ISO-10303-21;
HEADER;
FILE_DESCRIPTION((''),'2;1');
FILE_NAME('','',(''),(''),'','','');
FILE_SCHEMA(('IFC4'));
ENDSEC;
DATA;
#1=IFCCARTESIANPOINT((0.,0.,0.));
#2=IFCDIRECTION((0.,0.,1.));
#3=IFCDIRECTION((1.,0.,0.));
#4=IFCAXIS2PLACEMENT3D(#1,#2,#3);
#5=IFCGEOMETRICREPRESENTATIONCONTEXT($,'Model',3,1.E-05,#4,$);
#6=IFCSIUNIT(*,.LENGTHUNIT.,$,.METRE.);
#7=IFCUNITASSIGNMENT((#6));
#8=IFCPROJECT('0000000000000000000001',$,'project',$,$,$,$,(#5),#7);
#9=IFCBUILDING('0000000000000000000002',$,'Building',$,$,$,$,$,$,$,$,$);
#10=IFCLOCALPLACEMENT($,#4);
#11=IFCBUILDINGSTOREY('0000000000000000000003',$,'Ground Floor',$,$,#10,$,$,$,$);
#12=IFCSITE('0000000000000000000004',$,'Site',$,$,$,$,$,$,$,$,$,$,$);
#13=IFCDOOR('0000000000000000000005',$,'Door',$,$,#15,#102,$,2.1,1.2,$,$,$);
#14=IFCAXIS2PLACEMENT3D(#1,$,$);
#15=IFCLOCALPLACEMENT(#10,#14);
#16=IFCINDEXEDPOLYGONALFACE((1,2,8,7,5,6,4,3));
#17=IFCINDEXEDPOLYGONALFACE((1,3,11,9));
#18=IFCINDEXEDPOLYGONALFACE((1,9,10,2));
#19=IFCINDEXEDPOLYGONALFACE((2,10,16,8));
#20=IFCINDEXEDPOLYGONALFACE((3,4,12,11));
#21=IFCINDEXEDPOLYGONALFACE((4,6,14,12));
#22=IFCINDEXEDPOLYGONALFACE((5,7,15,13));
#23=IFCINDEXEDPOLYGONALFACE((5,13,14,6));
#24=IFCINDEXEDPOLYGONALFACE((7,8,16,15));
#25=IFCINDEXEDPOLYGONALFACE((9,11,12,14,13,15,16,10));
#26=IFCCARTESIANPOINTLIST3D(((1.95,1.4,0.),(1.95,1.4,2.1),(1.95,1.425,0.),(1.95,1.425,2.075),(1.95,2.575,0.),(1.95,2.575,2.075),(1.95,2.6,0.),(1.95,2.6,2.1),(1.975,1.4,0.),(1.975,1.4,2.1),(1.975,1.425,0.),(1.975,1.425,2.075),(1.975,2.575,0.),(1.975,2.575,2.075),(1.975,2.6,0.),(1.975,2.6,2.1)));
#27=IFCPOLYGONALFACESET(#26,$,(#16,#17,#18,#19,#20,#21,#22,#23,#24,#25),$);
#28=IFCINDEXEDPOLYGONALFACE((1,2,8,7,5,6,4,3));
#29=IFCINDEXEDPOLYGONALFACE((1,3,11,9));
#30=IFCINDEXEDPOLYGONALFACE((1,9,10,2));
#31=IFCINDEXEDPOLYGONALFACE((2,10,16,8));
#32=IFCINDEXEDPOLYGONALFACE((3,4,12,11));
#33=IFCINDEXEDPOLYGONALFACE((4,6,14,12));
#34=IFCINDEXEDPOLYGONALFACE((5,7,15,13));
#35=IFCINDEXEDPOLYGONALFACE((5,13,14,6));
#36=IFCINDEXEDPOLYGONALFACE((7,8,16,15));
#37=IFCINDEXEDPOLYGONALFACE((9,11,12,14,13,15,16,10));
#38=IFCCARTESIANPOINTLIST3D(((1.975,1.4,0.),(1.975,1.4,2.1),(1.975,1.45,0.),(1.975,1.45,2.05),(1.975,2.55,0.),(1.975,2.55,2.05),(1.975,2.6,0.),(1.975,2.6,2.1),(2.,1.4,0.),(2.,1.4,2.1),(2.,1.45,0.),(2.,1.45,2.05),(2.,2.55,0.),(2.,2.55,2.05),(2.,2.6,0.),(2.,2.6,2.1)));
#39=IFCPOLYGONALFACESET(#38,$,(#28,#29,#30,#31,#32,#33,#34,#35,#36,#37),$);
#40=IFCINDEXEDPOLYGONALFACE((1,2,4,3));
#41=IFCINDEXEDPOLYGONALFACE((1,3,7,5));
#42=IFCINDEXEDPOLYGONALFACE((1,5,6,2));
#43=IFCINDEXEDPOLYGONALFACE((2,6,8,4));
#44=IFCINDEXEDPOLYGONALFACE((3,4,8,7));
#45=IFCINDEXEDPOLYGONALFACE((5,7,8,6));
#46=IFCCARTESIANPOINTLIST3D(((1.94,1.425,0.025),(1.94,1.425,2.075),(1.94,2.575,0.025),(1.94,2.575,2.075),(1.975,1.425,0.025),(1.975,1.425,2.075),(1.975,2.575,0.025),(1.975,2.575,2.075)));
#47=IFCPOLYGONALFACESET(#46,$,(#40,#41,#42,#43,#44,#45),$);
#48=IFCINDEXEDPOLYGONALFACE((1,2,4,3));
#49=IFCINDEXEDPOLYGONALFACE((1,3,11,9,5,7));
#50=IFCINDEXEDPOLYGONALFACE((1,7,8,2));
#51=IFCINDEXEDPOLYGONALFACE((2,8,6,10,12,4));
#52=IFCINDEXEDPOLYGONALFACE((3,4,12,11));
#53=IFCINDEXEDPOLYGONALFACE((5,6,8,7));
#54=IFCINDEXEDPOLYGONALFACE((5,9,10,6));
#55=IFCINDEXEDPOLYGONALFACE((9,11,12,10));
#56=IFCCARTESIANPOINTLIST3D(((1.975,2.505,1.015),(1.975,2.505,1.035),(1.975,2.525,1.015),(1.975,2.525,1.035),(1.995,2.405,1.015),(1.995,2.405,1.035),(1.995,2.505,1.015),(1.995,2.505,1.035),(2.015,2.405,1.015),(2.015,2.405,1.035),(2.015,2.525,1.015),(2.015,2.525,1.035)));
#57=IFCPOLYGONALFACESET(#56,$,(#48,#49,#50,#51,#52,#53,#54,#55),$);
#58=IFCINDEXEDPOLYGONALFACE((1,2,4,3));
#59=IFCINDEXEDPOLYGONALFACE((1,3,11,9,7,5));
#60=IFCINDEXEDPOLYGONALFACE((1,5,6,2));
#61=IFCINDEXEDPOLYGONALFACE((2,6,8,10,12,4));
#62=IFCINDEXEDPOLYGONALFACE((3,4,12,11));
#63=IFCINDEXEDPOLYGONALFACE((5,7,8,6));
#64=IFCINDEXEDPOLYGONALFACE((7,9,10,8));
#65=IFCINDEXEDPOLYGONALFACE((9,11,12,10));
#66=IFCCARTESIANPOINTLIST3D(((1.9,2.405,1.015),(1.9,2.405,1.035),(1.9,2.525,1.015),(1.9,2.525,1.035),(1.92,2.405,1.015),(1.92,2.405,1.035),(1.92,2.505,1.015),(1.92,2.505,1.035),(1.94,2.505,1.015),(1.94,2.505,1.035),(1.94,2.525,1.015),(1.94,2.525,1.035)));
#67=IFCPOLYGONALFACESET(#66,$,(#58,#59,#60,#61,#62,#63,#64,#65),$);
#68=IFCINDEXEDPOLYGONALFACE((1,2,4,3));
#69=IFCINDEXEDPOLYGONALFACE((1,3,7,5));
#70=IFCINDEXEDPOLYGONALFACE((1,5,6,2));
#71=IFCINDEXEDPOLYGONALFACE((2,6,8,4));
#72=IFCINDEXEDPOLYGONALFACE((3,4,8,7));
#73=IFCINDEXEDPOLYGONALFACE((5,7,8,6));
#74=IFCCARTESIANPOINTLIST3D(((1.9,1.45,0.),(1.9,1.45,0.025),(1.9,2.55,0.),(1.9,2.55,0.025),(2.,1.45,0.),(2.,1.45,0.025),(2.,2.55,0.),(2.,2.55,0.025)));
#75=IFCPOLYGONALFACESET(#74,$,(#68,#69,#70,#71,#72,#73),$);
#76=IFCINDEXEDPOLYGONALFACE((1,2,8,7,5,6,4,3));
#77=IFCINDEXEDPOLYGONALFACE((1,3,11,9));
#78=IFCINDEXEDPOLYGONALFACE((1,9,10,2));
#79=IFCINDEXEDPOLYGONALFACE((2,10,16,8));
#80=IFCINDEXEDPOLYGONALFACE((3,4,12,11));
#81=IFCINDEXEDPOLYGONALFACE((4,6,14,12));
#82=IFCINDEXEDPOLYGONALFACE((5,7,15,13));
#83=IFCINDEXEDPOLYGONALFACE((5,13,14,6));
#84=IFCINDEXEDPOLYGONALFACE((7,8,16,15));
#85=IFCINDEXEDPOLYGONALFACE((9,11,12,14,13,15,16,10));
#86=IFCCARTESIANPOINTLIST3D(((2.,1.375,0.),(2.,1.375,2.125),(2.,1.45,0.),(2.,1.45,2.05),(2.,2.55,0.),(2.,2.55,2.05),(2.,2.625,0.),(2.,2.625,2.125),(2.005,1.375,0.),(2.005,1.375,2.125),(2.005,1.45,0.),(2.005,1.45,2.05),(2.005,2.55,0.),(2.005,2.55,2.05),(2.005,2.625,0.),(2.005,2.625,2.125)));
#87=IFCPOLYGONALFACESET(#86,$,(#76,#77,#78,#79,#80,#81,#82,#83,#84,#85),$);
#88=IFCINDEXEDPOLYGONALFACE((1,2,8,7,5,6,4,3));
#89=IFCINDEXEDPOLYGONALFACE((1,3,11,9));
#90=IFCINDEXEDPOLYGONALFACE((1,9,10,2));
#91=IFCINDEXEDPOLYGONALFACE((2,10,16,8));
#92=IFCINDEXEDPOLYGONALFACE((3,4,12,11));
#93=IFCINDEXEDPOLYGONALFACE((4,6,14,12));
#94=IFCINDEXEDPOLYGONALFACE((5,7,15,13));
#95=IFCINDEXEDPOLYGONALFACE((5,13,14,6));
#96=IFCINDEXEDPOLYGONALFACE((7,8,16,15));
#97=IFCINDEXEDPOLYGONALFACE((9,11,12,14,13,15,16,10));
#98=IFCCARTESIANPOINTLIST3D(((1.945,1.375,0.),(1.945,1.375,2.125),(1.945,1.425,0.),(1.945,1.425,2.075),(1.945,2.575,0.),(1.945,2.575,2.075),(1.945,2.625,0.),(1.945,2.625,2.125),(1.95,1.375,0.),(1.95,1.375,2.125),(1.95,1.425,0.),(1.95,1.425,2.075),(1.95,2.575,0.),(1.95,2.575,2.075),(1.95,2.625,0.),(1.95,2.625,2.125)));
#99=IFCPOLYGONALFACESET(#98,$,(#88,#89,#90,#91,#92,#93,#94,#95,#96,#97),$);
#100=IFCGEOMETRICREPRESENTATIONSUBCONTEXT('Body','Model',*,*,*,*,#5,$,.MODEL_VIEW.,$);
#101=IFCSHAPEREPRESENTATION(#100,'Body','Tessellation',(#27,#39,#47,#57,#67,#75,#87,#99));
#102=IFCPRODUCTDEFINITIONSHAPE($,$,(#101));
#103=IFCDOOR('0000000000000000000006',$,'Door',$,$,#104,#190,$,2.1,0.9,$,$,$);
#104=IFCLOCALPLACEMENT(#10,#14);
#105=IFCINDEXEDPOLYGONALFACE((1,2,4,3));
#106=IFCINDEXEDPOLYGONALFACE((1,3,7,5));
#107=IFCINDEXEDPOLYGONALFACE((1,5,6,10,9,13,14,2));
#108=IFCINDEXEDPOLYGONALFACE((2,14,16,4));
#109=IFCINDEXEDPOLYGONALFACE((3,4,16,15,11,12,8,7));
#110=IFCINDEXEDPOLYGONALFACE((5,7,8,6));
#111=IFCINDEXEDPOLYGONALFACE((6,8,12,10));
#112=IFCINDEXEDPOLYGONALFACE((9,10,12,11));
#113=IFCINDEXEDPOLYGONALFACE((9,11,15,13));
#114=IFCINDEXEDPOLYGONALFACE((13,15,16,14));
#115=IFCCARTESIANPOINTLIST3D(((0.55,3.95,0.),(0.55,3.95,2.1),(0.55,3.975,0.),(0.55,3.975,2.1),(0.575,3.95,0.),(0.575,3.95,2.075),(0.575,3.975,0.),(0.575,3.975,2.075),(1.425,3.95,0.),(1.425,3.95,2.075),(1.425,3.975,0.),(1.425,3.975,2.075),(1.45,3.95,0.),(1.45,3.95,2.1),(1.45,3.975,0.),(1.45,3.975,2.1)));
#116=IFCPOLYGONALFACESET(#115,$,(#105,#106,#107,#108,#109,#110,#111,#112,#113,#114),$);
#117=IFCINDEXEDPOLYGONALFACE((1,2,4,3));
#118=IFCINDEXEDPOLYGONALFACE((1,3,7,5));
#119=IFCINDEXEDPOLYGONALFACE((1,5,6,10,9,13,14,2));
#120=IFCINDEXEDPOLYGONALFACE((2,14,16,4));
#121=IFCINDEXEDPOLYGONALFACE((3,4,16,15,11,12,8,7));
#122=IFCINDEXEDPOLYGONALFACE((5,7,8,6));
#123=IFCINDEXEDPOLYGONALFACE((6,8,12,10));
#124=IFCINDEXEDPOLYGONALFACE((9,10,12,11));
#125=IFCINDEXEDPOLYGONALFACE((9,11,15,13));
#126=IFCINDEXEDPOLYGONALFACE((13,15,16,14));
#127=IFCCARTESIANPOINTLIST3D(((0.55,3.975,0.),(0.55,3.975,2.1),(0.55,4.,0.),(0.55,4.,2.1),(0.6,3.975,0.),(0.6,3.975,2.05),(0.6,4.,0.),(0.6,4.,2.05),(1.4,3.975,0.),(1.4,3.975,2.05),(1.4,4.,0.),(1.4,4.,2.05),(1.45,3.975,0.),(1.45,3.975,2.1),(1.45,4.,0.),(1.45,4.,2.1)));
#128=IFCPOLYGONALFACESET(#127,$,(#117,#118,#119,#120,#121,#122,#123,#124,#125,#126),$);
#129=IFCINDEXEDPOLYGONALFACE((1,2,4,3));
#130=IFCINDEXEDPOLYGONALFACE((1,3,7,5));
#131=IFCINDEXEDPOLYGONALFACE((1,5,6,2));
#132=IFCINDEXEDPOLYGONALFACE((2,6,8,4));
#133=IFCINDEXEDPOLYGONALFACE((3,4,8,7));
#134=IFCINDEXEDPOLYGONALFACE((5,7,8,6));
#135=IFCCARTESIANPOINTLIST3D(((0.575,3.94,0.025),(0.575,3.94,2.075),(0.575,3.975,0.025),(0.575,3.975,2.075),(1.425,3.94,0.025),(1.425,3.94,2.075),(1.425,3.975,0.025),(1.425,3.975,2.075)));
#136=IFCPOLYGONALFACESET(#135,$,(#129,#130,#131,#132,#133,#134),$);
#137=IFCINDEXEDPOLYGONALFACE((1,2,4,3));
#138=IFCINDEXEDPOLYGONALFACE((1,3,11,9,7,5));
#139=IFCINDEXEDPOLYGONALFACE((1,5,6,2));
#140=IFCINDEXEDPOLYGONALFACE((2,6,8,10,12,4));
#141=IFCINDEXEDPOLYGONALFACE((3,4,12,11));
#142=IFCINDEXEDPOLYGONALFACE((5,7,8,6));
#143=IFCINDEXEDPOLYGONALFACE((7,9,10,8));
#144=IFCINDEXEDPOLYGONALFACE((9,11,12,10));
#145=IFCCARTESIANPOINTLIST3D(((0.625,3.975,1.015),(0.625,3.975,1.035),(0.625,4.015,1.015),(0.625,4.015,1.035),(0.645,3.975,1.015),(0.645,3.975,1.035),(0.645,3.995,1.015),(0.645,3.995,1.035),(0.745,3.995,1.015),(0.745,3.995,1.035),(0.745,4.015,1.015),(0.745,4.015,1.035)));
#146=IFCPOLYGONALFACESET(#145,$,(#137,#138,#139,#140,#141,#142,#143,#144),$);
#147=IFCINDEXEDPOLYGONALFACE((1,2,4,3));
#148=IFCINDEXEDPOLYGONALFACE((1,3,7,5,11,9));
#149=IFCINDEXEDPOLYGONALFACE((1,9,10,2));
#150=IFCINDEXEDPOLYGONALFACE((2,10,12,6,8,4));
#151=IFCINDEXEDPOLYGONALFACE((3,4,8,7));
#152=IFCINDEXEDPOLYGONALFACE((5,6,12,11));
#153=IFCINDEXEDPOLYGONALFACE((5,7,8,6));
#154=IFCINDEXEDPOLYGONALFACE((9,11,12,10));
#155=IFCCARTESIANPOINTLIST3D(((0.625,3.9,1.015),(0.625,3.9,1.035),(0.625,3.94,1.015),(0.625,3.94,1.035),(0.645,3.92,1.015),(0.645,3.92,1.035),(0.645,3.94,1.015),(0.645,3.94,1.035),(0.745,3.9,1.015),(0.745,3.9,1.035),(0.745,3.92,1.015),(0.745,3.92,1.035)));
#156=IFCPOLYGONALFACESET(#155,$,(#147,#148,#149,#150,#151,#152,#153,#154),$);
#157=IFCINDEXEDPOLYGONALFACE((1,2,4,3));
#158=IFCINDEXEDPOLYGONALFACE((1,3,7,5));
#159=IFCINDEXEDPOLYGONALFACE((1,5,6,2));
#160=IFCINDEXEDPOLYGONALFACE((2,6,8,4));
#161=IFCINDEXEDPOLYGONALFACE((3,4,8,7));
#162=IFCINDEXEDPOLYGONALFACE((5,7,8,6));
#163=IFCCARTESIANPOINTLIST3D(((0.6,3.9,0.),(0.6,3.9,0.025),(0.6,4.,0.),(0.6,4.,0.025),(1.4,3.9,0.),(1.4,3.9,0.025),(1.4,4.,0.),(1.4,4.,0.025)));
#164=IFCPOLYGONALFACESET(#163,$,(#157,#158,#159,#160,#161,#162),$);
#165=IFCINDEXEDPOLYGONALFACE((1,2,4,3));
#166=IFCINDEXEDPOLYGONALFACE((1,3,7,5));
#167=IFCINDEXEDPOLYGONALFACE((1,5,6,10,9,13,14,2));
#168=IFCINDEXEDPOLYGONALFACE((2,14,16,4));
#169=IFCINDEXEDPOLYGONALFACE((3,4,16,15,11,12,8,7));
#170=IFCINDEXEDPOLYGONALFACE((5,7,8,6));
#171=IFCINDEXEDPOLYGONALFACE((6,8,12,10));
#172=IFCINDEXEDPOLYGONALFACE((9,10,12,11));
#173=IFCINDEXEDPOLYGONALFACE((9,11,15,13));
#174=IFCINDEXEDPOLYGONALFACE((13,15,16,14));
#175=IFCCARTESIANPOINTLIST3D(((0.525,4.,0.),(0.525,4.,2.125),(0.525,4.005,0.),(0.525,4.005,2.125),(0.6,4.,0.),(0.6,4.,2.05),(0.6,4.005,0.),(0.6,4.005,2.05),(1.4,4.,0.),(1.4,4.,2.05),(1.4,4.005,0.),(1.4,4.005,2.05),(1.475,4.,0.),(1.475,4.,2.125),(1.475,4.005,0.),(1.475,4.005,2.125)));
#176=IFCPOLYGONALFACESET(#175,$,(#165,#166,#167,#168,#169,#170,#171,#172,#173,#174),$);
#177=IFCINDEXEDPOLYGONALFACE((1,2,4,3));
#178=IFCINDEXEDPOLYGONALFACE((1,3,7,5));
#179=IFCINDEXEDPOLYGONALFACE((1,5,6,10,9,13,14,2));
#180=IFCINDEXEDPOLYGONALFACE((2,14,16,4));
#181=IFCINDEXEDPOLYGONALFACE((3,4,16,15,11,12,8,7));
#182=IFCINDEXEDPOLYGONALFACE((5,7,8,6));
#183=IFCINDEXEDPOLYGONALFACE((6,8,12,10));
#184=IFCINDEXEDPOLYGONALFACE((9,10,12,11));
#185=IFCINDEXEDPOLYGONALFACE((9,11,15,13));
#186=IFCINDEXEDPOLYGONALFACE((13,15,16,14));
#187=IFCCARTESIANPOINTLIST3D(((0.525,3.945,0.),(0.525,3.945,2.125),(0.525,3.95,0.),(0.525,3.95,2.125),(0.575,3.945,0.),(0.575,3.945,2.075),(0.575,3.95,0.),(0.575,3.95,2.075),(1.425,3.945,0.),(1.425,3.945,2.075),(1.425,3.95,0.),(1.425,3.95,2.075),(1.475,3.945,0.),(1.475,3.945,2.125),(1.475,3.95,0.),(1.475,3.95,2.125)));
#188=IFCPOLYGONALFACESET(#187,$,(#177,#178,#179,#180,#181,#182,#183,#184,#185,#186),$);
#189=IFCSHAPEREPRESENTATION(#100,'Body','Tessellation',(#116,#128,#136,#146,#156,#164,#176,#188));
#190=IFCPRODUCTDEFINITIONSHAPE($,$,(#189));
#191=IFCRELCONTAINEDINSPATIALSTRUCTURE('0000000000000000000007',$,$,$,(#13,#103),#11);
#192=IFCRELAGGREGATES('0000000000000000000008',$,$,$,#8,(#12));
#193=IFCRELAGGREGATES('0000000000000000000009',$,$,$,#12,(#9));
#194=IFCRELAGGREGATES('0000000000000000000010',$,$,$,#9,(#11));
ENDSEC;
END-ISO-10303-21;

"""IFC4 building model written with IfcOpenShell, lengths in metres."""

from ifc_helpers import new_model, si_unit, frame, origin_with_axes, place, context, subcontext, project, spatial, line, indexed_curve, outline, extrude, element, save


model = new_model("IFC4")

# Units and contexts
model_context = context("Model", 3, precision=1e-05, world=origin_with_axes())
body_context = subcontext(model_context, "Body", "Model", "MODEL_VIEW")
ifc_project = project(units=[si_unit("LENGTHUNIT", "METRE")], contexts=[model_context])

# Site, building, storey
site = spatial("IfcSite", under=ifc_project, Name="Site")
building = spatial("IfcBuilding", under=site, Name="Building")
storey_placement = place(None, origin_with_axes())
storey = spatial("IfcBuildingStorey", under=building, at=storey_placement, Name="Ground Floor")

# Doors
door_1_placement = place(storey_placement, frame((2.0, 1.4, 0.0), z_axis=(0.0, 0.0, 1.0), x_axis=(0.0, 1.0, 0.0)))
element("IfcDoor", 1, at=door_1_placement, inside=storey, Name="Door", OverallHeight=2.1, OverallWidth=1.2, context=body_context, shape_type="SweptSolid", body=[
    extrude(outline(indexed_curve([(0.0, 0.0), (0.0, 2.1), (1.2, 2.1), (1.2, 0.0), (1.175, 0.0), (1.175, 2.075), (0.025, 2.075), (0.025, 0.0)], segments=[line(1, 2, 3, 4, 5, 6, 7, 8, 1)])), frame((0.0, 0.025, 0.0), z_axis=(0.0, -1.0, 0.0), x_axis=(1.0, 0.0, 0.0)), (0.0, 0.0, -1.0), 0.025),
    extrude(outline(indexed_curve([(0.0, 0.0), (0.0, 2.1), (1.2, 2.1), (1.2, 0.0), (1.15, 0.0), (1.15, 2.05), (0.05, 2.05), (0.05, 0.0)], segments=[line(1, 2, 3, 4, 5, 6, 7, 8, 1)])), frame((0.0, 0.0, 0.0), z_axis=(0.0, -1.0, 0.0), x_axis=(1.0, 0.0, 0.0)), (0.0, 0.0, -1.0), 0.025),
    extrude(outline(indexed_curve([(0.0, 0.0), (1.15, 0.0), (1.15, 0.035), (0.0, 0.035)], segments=[line(1, 2, 3, 4, 1)])), frame((0.025, 0.025, 0.025), z_axis=(0.0, 0.0, 1.0), x_axis=(1.0, 0.0, 0.0)), (0.0, 0.0, 1.0), 2.05),
    extrude(outline(indexed_curve([(0.0, 0.0), (0.0, -0.04), (-0.12, -0.04), (-0.12, -0.02), (-0.02, -0.02), (-0.02, 0.0)], segments=[line(1, 2, 3, 4, 5, 6, 1)])), frame((1.125, 0.025, 1.015), z_axis=(0.0, 0.0, 1.0), x_axis=(1.0, 0.0, 0.0)), (0.0, 0.0, 1.0), 0.02),
    extrude(outline(indexed_curve([(0.0, 0.0), (0.0, 0.04), (-0.12, 0.04), (-0.12, 0.02), (-0.02, 0.02), (-0.02, 0.0)], segments=[line(1, 2, 3, 4, 5, 6, 1)])), frame((1.125, 0.06, 1.015), z_axis=(0.0, 0.0, 1.0), x_axis=(1.0, 0.0, 0.0)), (0.0, 0.0, 1.0), 0.02),
    extrude(outline(indexed_curve([(0.0, 0.0), (1.1, 0.0), (1.1, 0.1), (0.0, 0.1)], segments=[line(1, 2, 3, 4, 1)])), frame((0.05, 0.0, 0.0), z_axis=(0.0, 0.0, 1.0), x_axis=(1.0, 0.0, 0.0)), (0.0, 0.0, 1.0), 0.025),
    extrude(outline(indexed_curve([(0.0, 0.0), (0.0, 2.125), (1.25, 2.125), (1.25, 0.0), (1.175, 0.0), (1.175, 2.05), (0.075, 2.05), (0.075, 0.0)], segments=[line(1, 2, 3, 4, 5, 6, 7, 8, 1)])), frame((-0.025, -0.005, 0.0), z_axis=(0.0, -1.0, 0.0), x_axis=(1.0, 0.0, 0.0)), (0.0, 0.0, -1.0), 0.005),
    extrude(outline(indexed_curve([(0.0, 0.0), (0.0, 2.125), (1.25, 2.125), (1.25, 0.0), (1.2, 0.0), (1.2, 2.075), (0.05, 2.075), (0.05, 0.0)], segments=[line(1, 2, 3, 4, 5, 6, 7, 8, 1)])), frame((-0.025, 0.05, 0.0), z_axis=(0.0, -1.0, 0.0), x_axis=(1.0, 0.0, 0.0)), (0.0, 0.0, -1.0), 0.005),
])
door_2_placement = place(storey_placement, frame((1.45, 4.0, 0.0), z_axis=(0.0, 0.0, 1.0), x_axis=(-1.0, 0.0, 0.0)))
element("IfcDoor", 2, at=door_2_placement, inside=storey, Name="Door", OverallHeight=2.1, OverallWidth=0.9, context=body_context, shape_type="SweptSolid", body=[
    extrude(outline(indexed_curve([(0.0, 0.0), (0.0, 2.1), (0.9, 2.1), (0.9, 0.0), (0.875, 0.0), (0.875, 2.075), (0.025, 2.075), (0.025, 0.0)], segments=[line(1, 2, 3, 4, 5, 6, 7, 8, 1)])), frame((0.0, 0.025, 0.0), z_axis=(0.0, -1.0, 0.0), x_axis=(1.0, 0.0, 0.0)), (0.0, 0.0, -1.0), 0.025),
    extrude(outline(indexed_curve([(0.0, 0.0), (0.0, 2.1), (0.9, 2.1), (0.9, 0.0), (0.85, 0.0), (0.85, 2.05), (0.05, 2.05), (0.05, 0.0)], segments=[line(1, 2, 3, 4, 5, 6, 7, 8, 1)])), frame((0.0, 0.0, 0.0), z_axis=(0.0, -1.0, 0.0), x_axis=(1.0, 0.0, 0.0)), (0.0, 0.0, -1.0), 0.025),
    extrude(outline(indexed_curve([(0.0, 0.0), (0.85, 0.0), (0.85, 0.035), (0.0, 0.035)], segments=[line(1, 2, 3, 4, 1)])), frame((0.025, 0.025, 0.025), z_axis=(0.0, 0.0, 1.0), x_axis=(1.0, 0.0, 0.0)), (0.0, 0.0, 1.0), 2.05),
    extrude(outline(indexed_curve([(0.0, 0.0), (0.0, -0.04), (-0.12, -0.04), (-0.12, -0.02), (-0.02, -0.02), (-0.02, 0.0)], segments=[line(1, 2, 3, 4, 5, 6, 1)])), frame((0.825, 0.025, 1.015), z_axis=(0.0, 0.0, 1.0), x_axis=(1.0, 0.0, 0.0)), (0.0, 0.0, 1.0), 0.02),
    extrude(outline(indexed_curve([(0.0, 0.0), (0.0, 0.04), (-0.12, 0.04), (-0.12, 0.02), (-0.02, 0.02), (-0.02, 0.0)], segments=[line(1, 2, 3, 4, 5, 6, 1)])), frame((0.825, 0.06, 1.015), z_axis=(0.0, 0.0, 1.0), x_axis=(1.0, 0.0, 0.0)), (0.0, 0.0, 1.0), 0.02),
    extrude(outline(indexed_curve([(0.0, 0.0), (0.8, 0.0), (0.8, 0.1), (0.0, 0.1)], segments=[line(1, 2, 3, 4, 1)])), frame((0.05, 0.0, 0.0), z_axis=(0.0, 0.0, 1.0), x_axis=(1.0, 0.0, 0.0)), (0.0, 0.0, 1.0), 0.025),
    extrude(outline(indexed_curve([(0.0, 0.0), (0.0, 2.125), (0.95, 2.125), (0.95, 0.0), (0.875, 0.0), (0.875, 2.05), (0.075, 2.05), (0.075, 0.0)], segments=[line(1, 2, 3, 4, 5, 6, 7, 8, 1)])), frame((-0.025, -0.005, 0.0), z_axis=(0.0, -1.0, 0.0), x_axis=(1.0, 0.0, 0.0)), (0.0, 0.0, -1.0), 0.005),
    extrude(outline(indexed_curve([(0.0, 0.0), (0.0, 2.125), (0.95, 2.125), (0.95, 0.0), (0.9, 0.0), (0.9, 2.075), (0.05, 2.075), (0.05, 0.0)], segments=[line(1, 2, 3, 4, 5, 6, 7, 8, 1)])), frame((-0.025, 0.05, 0.0), z_axis=(0.0, -1.0, 0.0), x_axis=(1.0, 0.0, 0.0)), (0.0, 0.0, -1.0), 0.005),
])

save(model, "model.ifc")
